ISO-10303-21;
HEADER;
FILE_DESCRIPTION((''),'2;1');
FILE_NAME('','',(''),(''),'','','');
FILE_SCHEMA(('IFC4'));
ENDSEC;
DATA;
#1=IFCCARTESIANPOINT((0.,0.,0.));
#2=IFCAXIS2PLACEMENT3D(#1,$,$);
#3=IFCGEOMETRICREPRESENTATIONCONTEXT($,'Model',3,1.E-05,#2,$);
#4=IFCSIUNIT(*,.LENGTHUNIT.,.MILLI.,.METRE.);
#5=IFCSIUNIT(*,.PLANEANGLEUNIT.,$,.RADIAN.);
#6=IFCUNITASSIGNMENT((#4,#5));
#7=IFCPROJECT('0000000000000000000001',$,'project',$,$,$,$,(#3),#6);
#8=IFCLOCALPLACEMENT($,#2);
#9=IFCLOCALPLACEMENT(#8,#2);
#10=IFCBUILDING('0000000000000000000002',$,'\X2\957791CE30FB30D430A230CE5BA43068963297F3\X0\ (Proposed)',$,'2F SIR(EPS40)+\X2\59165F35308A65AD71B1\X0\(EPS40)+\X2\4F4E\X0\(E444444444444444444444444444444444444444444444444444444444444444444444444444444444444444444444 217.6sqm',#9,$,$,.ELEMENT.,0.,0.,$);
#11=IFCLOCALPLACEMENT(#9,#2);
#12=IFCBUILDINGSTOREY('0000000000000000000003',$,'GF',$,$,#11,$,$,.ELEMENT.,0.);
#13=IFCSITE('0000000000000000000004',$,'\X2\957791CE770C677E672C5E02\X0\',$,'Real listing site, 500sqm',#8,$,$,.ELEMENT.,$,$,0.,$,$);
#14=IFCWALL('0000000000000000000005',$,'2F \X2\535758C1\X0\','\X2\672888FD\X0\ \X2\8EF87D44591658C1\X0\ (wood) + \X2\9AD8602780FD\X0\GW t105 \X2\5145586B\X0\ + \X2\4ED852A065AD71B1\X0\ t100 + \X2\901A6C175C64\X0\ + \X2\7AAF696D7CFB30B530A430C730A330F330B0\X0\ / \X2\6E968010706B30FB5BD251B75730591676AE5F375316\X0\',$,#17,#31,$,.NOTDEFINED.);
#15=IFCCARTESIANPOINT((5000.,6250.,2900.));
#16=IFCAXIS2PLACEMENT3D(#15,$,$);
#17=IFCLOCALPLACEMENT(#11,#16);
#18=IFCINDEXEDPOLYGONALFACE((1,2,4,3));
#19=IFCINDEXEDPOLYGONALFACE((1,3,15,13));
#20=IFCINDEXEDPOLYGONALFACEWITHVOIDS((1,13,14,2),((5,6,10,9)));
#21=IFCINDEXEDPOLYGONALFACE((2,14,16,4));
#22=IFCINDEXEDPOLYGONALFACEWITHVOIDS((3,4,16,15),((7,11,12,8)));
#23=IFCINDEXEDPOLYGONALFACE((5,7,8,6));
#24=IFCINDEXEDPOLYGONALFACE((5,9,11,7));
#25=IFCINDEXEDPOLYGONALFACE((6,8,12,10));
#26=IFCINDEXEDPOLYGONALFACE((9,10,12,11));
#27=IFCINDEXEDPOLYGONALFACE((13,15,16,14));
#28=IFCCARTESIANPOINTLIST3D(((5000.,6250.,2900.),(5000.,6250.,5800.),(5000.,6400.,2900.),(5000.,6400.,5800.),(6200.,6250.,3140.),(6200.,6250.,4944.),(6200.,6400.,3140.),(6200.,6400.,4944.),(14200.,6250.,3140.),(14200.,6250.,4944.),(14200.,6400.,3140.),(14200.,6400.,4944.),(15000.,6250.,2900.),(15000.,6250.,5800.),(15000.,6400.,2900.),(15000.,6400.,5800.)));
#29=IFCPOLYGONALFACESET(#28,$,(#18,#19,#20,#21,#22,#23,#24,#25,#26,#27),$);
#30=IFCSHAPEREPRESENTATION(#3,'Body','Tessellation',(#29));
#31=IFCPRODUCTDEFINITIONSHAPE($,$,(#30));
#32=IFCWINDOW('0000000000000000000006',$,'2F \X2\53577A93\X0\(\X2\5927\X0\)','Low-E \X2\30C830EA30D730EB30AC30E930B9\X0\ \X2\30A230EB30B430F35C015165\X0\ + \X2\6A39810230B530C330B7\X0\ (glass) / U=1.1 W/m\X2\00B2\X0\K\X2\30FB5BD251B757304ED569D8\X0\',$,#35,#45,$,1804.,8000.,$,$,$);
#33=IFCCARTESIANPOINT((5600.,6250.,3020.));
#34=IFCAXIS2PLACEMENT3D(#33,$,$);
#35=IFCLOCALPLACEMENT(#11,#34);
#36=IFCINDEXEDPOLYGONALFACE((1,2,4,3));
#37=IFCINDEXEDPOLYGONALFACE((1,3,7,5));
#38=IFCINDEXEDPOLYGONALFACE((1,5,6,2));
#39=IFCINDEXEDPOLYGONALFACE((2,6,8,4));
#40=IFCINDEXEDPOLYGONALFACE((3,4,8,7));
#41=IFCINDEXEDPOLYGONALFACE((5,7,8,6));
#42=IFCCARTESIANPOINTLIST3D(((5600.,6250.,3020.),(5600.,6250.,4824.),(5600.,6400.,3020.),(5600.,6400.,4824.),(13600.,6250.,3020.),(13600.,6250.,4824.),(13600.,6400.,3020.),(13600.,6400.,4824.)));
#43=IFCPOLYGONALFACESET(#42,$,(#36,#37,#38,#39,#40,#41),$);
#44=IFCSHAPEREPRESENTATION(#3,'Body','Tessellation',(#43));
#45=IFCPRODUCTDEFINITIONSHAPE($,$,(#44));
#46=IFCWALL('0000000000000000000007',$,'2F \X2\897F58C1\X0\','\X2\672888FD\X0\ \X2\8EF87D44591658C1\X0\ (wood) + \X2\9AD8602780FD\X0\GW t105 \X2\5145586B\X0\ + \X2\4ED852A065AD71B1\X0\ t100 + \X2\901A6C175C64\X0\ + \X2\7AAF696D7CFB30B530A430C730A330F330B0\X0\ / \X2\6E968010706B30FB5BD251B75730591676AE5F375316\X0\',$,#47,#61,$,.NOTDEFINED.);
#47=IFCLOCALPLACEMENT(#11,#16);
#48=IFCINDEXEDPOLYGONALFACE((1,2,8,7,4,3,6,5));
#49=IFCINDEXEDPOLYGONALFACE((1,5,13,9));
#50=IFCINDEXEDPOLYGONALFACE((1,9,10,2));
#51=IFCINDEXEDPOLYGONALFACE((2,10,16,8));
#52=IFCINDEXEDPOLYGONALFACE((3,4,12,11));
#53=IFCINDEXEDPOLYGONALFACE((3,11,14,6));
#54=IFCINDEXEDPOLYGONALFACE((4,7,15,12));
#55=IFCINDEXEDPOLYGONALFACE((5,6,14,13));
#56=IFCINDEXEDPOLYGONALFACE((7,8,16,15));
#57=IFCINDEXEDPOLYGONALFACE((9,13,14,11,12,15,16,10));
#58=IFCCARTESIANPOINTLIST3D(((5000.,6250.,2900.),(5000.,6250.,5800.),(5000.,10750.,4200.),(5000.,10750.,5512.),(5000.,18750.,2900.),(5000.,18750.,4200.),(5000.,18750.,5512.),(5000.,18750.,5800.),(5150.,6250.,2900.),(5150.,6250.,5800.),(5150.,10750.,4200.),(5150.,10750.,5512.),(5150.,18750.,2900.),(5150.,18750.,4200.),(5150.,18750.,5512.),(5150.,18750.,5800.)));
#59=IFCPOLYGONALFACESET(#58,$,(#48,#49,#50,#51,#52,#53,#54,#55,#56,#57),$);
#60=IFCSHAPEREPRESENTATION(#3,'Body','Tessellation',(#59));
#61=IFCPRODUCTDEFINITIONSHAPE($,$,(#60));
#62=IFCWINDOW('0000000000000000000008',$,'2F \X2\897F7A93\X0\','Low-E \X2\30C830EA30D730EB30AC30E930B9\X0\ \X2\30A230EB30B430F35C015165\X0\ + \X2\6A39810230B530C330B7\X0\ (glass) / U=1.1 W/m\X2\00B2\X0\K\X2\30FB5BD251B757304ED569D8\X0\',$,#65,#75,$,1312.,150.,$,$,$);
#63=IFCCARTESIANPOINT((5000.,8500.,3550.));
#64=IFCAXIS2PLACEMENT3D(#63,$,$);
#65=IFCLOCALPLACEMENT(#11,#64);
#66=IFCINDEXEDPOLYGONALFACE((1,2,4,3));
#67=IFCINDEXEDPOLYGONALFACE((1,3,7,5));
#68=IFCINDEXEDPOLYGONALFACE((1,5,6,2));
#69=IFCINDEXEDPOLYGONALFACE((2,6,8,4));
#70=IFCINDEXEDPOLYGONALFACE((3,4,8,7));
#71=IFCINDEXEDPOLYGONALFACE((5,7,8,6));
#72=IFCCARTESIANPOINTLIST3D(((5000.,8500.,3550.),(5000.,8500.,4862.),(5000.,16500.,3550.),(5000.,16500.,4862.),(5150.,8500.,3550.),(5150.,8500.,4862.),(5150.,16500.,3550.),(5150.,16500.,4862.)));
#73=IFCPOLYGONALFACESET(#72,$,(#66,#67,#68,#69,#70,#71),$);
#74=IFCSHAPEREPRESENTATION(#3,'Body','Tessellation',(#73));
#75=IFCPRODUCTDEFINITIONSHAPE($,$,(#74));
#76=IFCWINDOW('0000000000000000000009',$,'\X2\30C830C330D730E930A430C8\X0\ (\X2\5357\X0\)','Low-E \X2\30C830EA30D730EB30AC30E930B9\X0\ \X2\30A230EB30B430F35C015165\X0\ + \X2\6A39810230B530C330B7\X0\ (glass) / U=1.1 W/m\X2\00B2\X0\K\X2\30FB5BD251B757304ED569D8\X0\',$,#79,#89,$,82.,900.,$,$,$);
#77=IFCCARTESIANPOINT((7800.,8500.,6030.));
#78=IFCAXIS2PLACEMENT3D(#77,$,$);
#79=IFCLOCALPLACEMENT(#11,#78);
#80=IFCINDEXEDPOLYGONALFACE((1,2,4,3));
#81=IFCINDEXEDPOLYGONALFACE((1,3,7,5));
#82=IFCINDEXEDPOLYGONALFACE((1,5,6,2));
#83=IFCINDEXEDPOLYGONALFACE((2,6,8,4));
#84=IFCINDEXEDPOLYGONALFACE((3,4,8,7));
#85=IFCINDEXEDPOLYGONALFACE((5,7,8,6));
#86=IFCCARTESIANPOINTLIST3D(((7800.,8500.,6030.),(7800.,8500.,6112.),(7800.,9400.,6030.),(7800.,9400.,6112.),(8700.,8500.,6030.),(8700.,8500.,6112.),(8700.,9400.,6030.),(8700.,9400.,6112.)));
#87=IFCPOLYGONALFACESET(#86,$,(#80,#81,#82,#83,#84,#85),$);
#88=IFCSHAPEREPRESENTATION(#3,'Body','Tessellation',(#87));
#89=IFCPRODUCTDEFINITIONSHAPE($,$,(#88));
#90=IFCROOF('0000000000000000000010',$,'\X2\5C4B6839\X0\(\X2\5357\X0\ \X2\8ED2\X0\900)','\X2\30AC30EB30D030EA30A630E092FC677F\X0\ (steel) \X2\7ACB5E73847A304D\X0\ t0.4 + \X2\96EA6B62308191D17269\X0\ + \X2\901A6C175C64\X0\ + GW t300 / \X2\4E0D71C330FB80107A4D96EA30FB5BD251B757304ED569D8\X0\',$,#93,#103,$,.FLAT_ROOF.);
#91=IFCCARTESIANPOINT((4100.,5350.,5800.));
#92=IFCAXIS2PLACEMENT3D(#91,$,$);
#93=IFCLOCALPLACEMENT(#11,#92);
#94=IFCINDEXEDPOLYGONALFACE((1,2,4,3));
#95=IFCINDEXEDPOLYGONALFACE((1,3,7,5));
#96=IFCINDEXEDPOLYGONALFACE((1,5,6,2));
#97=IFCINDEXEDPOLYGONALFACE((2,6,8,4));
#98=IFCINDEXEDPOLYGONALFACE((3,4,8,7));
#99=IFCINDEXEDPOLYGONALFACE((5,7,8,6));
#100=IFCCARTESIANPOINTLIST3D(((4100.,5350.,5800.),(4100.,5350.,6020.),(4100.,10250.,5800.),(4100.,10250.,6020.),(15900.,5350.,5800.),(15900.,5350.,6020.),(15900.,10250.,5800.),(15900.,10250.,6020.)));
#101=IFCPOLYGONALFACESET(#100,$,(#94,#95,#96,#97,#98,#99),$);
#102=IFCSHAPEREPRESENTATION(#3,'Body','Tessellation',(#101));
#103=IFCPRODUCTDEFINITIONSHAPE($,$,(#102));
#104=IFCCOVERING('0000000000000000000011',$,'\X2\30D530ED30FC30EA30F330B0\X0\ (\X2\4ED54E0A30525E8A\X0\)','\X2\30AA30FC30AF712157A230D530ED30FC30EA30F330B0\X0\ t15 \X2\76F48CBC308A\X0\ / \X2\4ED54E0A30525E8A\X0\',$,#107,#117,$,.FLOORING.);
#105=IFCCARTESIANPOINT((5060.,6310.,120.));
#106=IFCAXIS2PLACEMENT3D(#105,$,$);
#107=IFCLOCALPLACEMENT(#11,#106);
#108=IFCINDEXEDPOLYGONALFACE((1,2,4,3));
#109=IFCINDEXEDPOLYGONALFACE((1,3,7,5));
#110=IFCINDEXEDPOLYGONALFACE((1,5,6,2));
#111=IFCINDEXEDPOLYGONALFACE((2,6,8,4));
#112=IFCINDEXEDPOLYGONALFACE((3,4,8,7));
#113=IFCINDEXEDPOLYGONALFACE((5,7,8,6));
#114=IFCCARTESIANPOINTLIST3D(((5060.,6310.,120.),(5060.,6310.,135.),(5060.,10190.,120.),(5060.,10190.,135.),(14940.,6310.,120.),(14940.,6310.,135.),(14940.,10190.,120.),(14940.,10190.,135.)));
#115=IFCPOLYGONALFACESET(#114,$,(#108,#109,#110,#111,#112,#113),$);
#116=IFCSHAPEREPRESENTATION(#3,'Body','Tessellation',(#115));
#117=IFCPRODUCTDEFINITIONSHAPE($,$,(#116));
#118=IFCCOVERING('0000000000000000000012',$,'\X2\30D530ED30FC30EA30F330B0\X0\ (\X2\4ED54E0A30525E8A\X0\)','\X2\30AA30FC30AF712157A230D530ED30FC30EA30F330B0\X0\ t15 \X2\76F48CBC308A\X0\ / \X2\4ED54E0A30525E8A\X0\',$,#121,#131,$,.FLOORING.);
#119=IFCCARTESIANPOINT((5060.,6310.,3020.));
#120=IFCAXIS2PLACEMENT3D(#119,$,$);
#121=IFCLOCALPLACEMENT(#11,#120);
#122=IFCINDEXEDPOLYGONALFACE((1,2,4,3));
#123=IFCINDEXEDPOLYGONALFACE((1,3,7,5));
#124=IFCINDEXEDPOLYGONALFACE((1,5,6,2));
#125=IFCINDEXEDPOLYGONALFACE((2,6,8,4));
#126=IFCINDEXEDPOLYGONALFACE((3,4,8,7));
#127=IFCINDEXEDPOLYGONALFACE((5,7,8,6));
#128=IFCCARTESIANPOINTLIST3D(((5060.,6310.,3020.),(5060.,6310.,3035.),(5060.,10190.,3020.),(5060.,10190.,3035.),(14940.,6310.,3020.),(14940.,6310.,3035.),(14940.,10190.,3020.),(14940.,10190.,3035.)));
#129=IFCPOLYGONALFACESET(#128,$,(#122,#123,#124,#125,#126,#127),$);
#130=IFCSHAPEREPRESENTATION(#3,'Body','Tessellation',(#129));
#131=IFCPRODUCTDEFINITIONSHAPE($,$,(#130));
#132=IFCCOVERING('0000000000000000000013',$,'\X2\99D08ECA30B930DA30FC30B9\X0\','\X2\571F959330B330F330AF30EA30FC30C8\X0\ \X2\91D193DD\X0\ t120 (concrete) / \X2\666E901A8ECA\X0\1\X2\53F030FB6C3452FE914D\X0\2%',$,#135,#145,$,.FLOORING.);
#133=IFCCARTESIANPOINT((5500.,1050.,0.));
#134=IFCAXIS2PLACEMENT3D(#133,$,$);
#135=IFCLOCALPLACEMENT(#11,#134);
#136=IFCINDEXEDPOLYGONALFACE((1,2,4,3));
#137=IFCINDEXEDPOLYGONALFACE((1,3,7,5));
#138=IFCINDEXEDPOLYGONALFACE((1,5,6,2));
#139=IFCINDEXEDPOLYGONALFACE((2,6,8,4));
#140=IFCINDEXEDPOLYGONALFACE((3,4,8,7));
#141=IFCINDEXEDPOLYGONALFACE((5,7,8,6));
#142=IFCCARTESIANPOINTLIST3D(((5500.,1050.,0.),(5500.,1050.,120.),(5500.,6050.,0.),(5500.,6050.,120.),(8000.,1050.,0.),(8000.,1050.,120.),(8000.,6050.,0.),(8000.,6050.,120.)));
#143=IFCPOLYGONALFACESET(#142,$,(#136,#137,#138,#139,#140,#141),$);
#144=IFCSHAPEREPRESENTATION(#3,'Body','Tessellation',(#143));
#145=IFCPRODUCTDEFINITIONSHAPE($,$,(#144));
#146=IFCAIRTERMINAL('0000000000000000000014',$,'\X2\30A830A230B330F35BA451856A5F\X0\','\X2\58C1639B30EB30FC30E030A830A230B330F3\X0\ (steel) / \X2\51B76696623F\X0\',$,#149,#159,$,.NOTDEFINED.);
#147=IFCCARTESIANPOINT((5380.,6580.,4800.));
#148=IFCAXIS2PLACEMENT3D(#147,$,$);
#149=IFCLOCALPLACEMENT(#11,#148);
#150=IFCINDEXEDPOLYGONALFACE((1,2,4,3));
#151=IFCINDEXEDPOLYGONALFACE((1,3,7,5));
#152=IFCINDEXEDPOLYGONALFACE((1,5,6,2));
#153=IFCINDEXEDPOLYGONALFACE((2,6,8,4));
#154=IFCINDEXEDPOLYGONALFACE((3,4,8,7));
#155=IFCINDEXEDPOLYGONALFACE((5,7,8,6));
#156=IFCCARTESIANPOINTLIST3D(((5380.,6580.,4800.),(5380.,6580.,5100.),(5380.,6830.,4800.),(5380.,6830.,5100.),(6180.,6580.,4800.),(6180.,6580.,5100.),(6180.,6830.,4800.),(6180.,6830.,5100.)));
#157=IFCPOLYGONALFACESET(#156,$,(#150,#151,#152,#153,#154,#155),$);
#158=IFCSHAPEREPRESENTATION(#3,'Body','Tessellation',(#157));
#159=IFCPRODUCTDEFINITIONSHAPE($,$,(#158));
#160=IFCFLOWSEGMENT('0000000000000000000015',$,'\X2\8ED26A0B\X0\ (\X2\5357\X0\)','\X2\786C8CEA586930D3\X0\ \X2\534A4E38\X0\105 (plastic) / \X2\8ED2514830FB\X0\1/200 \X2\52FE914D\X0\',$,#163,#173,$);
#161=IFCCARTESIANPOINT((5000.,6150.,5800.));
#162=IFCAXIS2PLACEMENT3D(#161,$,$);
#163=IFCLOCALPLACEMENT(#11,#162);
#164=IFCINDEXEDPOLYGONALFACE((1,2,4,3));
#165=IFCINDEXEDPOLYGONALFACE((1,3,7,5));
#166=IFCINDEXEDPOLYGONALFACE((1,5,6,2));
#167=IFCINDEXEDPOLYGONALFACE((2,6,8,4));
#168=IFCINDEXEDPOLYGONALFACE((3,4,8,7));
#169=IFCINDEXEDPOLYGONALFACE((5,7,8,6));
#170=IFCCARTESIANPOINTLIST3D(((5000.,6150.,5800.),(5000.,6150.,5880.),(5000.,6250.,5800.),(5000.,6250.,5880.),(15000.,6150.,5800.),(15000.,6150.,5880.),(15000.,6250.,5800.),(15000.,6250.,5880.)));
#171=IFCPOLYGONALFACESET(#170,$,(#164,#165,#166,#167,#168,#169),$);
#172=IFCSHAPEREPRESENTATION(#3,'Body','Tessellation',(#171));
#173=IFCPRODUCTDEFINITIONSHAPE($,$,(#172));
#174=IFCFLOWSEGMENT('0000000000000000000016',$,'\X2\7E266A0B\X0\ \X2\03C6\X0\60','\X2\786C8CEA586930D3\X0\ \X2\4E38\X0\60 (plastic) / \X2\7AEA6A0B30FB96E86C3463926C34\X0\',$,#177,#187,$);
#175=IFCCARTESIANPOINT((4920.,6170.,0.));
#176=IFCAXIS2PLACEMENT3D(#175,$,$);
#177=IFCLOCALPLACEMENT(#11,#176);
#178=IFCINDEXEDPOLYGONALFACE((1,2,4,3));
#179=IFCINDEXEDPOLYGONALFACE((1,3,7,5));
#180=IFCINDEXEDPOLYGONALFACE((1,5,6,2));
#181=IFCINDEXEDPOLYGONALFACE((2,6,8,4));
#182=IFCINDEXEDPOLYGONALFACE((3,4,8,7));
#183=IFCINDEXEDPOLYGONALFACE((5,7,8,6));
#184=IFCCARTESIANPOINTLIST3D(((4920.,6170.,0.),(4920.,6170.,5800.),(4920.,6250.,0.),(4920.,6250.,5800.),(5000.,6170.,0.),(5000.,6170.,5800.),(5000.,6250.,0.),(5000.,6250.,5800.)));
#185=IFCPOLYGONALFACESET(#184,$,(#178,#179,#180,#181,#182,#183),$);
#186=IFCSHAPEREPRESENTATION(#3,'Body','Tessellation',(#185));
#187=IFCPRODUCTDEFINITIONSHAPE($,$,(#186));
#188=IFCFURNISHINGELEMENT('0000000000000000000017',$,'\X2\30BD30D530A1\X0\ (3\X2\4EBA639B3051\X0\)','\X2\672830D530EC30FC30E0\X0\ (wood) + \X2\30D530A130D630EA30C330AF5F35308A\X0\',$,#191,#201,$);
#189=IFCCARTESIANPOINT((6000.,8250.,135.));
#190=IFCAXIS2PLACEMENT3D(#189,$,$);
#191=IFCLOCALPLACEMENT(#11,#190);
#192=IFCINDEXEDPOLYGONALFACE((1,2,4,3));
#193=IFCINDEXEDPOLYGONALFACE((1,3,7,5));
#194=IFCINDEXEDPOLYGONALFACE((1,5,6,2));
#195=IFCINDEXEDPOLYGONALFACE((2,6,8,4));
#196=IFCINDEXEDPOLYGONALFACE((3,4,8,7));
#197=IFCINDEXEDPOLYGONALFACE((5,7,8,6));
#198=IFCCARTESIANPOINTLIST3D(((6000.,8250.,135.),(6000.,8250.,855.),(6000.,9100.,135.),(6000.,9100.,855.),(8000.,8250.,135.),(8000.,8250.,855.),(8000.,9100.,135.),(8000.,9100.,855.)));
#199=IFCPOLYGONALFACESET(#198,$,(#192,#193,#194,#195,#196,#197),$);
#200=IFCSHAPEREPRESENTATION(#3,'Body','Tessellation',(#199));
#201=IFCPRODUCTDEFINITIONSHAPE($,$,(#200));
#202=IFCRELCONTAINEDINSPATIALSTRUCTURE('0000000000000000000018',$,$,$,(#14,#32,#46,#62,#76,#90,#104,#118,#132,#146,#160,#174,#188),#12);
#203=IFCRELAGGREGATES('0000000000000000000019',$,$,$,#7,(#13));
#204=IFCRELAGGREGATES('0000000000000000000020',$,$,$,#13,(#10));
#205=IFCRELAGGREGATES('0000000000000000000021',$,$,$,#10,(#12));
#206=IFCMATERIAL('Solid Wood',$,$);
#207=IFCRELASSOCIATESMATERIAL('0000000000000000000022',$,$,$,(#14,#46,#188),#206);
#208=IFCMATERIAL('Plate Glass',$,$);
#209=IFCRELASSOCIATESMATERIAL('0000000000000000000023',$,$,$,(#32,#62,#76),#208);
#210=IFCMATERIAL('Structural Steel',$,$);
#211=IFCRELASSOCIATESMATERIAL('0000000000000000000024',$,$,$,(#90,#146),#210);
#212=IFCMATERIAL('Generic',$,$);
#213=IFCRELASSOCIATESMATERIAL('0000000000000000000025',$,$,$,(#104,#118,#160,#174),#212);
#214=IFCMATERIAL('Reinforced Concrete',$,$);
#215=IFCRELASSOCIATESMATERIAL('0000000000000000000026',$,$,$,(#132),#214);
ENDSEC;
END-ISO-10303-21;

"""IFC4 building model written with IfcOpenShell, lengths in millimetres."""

from ifc_helpers import new_model, si_unit, frame, frame_2d, origin, place, context, project, spatial, rectangle, extrude, material, element, fill, save


model = new_model("IFC4")

# Units and contexts
model_context = context("Model", 3, precision=1e-05, world=origin())
ifc_project = project(units=[si_unit("LENGTHUNIT", "METRE", prefix="MILLI"), si_unit("PLANEANGLEUNIT", "RADIAN")], contexts=[model_context])

# Site, building, storey
site_placement = place(None, origin())
site = spatial("IfcSite", under=ifc_project, at=site_placement, Name="長野県松本市", ObjectType="Real listing site, 500sqm", CompositionType="ELEMENT", RefElevation=0.0)
building_placement = place(site_placement, origin())
building = spatial("IfcBuilding", under=site, at=building_placement, Name="長野・ピアノ室と防音 (Proposed)", ObjectType="2F SIR(EPS40)+外張り断熱(EPS40)+低(E444444444444444444444444444444444444444444444444444444444444444444444444444444444444444444444 217.6sqm", CompositionType="ELEMENT", ElevationOfRefHeight=0.0, ElevationOfTerrain=0.0)
storey_placement = place(building_placement, origin())
storey = spatial("IfcBuildingStorey", under=building, at=storey_placement, Name="GF", CompositionType="ELEMENT", Elevation=0.0)

# Shared definitions
ifc_material_1 = material(Name="Solid Wood")

# Shared definitions
ifc_material_2 = material(Name="Reinforced Concrete")

# Shared definitions
ifc_material_3 = material(Name="Plate Glass")

# Walls, openings, windows
wall_1_placement = place(storey_placement, frame((5000.0, 6250.0, 2900.0)))
wall_1 = element("IfcWall", 1, at=wall_1_placement, inside=storey, material=ifc_material_1, Name="2F 南壁", Description="木製 軸組外壁 (wood) + 高性能GW t105 充填 + 付加断熱 t100 + 通気層 + 窯業系サイディング / 準耐火・寒冷地外皮強化", PredefinedType="NOTDEFINED", context=model_context, shape_type="SweptSolid", body=[
    extrude(rectangle(XDim=10000.0, YDim=150.0, at=frame_2d((5000.0, 75.0))), frame((5000.0, 6250.0, 2900.0)), (0.0, 0.0, 1.0), 2900.0),
])
opening_1_placement = place(storey_placement, frame((5600.0, 6250.0, 3020.0)))
opening_1 = element("IfcOpeningElement", 2, at=opening_1_placement, cuts=wall_1, PredefinedType="NOTDEFINED", context=model_context, shape_type="SweptSolid", body=[
    extrude(rectangle(XDim=8000.0, YDim=150.0, at=frame_2d((4000.0, 75.0))), frame((5600.0, 6250.0, 3020.0)), (0.0, 0.0, 1.0), 1804.0),
])
window_1_placement = place(storey_placement, frame((5600.0, 6250.0, 3020.0)))
window_1 = element("IfcWindow", 3, at=window_1_placement, inside=storey, material=ifc_material_3, Name="2F 南窓(大)", Description="Low-E トリプルガラス アルゴン封入 + 樹脂サッシ (glass) / U=1.1 W/m²K・寒冷地仕様", OverallHeight=1804.0, OverallWidth=8000.0, context=model_context, shape_type="SweptSolid", body=[
    extrude(rectangle(XDim=8000.0, YDim=150.0, at=frame_2d((4000.0, 75.0))), frame((5600.0, 6250.0, 3020.0)), (0.0, 0.0, 1.0), 1804.0),
])
fill(opening_1, window_1)
wall_2_placement = place(storey_placement, frame((5000.0, 6250.0, 2900.0)))
wall_2 = element("IfcWall", 4, at=wall_2_placement, inside=storey, material=ifc_material_1, Name="2F 西壁", Description="木製 軸組外壁 (wood) + 高性能GW t105 充填 + 付加断熱 t100 + 通気層 + 窯業系サイディング / 準耐火・寒冷地外皮強化", PredefinedType="NOTDEFINED", context=model_context, shape_type="SweptSolid", body=[
    extrude(rectangle(XDim=150.0, YDim=12500.0, at=frame_2d((75.0, 6250.0))), frame((5000.0, 6250.0, 2900.0)), (0.0, 0.0, 1.0), 2900.0),
])
opening_2_placement = place(storey_placement, frame((5000.0, 8500.0, 3550.0)))
opening_2 = element("IfcOpeningElement", 5, at=opening_2_placement, cuts=wall_2, PredefinedType="NOTDEFINED", context=model_context, shape_type="SweptSolid", body=[
    extrude(rectangle(XDim=150.0, YDim=8000.0, at=frame_2d((75.0, 4000.0))), frame((5000.0, 8500.0, 3550.0)), (0.0, 0.0, 1.0), 1312.0),
])
window_2_placement = place(storey_placement, frame((5000.0, 8500.0, 3550.0)))
window_2 = element("IfcWindow", 6, at=window_2_placement, inside=storey, material=ifc_material_3, Name="2F 西窓", Description="Low-E トリプルガラス アルゴン封入 + 樹脂サッシ (glass) / U=1.1 W/m²K・寒冷地仕様", OverallHeight=1312.0, OverallWidth=150.0, context=model_context, shape_type="SweptSolid", body=[
    extrude(rectangle(XDim=150.0, YDim=8000.0, at=frame_2d((75.0, 4000.0))), frame((5000.0, 8500.0, 3550.0)), (0.0, 0.0, 1.0), 1312.0),
])
fill(opening_2, window_2)

# Window
window_3_placement = place(storey_placement, frame((7800.0, 8500.0, 6030.0)))
element("IfcWindow", 7, at=window_3_placement, inside=storey, material=ifc_material_3, Name="トップライト (南)", Description="Low-E トリプルガラス アルゴン封入 + 樹脂サッシ (glass) / U=1.1 W/m²K・寒冷地仕様", OverallHeight=82.0, OverallWidth=900.0, context=model_context, shape_type="SweptSolid", body=[
    extrude(rectangle(XDim=900.0, YDim=900.0, at=frame_2d((450.0, 450.0))), frame((7800.0, 8500.0, 6030.0)), (0.0, 0.0, 1.0), 82.0),
])

# Roof
ifc_material_4 = material(Name="Structural Steel")
for number, where, name in (
    (8, (4100.0, 5350.0, 5800.0), "屋根(南 軒900)"),
):
    element("IfcRoof", number, at=place(storey_placement, frame(where)), inside=storey, material=ifc_material_4, Name=name, Description="ガルバリウム鋼板 (steel) 立平葺き t0.4 + 雪止め金物 + 通気層 + GW t300 / 不燃・耐積雪・寒冷地仕様", PredefinedType="FLAT_ROOF", context=model_context, shape_type="SweptSolid", body=[
        extrude(rectangle(XDim=11800.0, YDim=4900.0, at=frame_2d((5900.0, 2450.0))), frame((4100.0, 5350.0, 5800.0)), (0.0, 0.0, 1.0), 220.0),
    ])

# Coverings
ifc_material_5 = material(Name="Generic")
covering_1_placement = place(storey_placement, frame((5060.0, 6310.0, 120.0)))
element("IfcCovering", 9, at=covering_1_placement, inside=storey, material=ifc_material_5, Name="フローリング (仕上げ床)", Description="オーク無垢フローリング t15 直貼り / 仕上げ床", PredefinedType="FLOORING", context=model_context, shape_type="SweptSolid", body=[
    extrude(rectangle(XDim=9880.0, YDim=3880.0, at=frame_2d((4940.0, 1940.0))), frame((5060.0, 6310.0, 120.0)), (0.0, 0.0, 1.0), 15.0),
])
covering_2_placement = place(storey_placement, frame((5060.0, 6310.0, 3020.0)))
element("IfcCovering", 10, at=covering_2_placement, inside=storey, material=ifc_material_5, Name="フローリング (仕上げ床)", Description="オーク無垢フローリング t15 直貼り / 仕上げ床", PredefinedType="FLOORING", context=model_context, shape_type="SweptSolid", body=[
    extrude(rectangle(XDim=9880.0, YDim=3880.0, at=frame_2d((4940.0, 1940.0))), frame((5060.0, 6310.0, 3020.0)), (0.0, 0.0, 1.0), 15.0),
])
covering_3_placement = place(storey_placement, frame((5500.0, 1050.0, 0.0)))
element("IfcCovering", 11, at=covering_3_placement, inside=storey, material=ifc_material_2, Name="駐車スペース", Description="土間コンクリート 金鏝 t120 (concrete) / 普通車1台・水勾配2%", PredefinedType="FLOORING", context=model_context, shape_type="SweptSolid", body=[
    extrude(rectangle(XDim=2500.0, YDim=5000.0, at=frame_2d((1250.0, 2500.0))), frame((5500.0, 1050.0, 0.0)), (0.0, 0.0, 1.0), 120.0),
])

# Air terminal
air_terminal_placement = place(storey_placement, frame((5380.0, 6580.0, 4800.0)))
element("IfcAirTerminal", 12, at=air_terminal_placement, inside=storey, material=ifc_material_4, Name="エアコン室内機", Description="壁掛ルームエアコン (steel) / 冷暖房", PredefinedType="NOTDEFINED", context=model_context, shape_type="SweptSolid", body=[
    extrude(rectangle(XDim=800.0, YDim=250.0, at=frame_2d((400.0, 125.0))), frame((5380.0, 6580.0, 4800.0)), (0.0, 0.0, 1.0), 300.0),
])

# Flow segments
flow_segment_1_placement = place(storey_placement, frame((5000.0, 6150.0, 5800.0)))
element("IfcFlowSegment", 13, at=flow_segment_1_placement, inside=storey, material=ifc_material_5, Name="軒樋 (南)", Description="硬質塩ビ 半丸105 (plastic) / 軒先・1/200 勾配", context=model_context, shape_type="SweptSolid", body=[
    extrude(rectangle(XDim=10000.0, YDim=100.0, at=frame_2d((5000.0, 50.0))), frame((5000.0, 6150.0, 5800.0)), (0.0, 0.0, 1.0), 80.0),
])
flow_segment_2_placement = place(storey_placement, frame((4920.0, 6170.0, 0.0)))
element("IfcFlowSegment", 14, at=flow_segment_2_placement, inside=storey, material=ifc_material_5, Name="縦樋 φ60", Description="硬質塩ビ 丸60 (plastic) / 竪樋・雨水排水", context=model_context, shape_type="SweptSolid", body=[
    extrude(rectangle(XDim=80.0, YDim=80.0, at=frame_2d((40.0, 40.0))), frame((4920.0, 6170.0, 0.0)), (0.0, 0.0, 1.0), 5800.0),
])

# Furnishing element
furnishing_1_placement = place(storey_placement, frame((6000.0, 8250.0, 135.0)))
element("IfcFurnishingElement", 15, at=furnishing_1_placement, inside=storey, material=ifc_material_1, Name="ソファ (3人掛け)", Description="木フレーム (wood) + ファブリック張り", context=model_context, shape_type="SweptSolid", body=[
    extrude(rectangle(XDim=2000.0, YDim=850.0, at=frame_2d((1000.0, 425.0))), frame((6000.0, 8250.0, 135.0)), (0.0, 0.0, 1.0), 720.0),
])

save(model, "model.ifc")
